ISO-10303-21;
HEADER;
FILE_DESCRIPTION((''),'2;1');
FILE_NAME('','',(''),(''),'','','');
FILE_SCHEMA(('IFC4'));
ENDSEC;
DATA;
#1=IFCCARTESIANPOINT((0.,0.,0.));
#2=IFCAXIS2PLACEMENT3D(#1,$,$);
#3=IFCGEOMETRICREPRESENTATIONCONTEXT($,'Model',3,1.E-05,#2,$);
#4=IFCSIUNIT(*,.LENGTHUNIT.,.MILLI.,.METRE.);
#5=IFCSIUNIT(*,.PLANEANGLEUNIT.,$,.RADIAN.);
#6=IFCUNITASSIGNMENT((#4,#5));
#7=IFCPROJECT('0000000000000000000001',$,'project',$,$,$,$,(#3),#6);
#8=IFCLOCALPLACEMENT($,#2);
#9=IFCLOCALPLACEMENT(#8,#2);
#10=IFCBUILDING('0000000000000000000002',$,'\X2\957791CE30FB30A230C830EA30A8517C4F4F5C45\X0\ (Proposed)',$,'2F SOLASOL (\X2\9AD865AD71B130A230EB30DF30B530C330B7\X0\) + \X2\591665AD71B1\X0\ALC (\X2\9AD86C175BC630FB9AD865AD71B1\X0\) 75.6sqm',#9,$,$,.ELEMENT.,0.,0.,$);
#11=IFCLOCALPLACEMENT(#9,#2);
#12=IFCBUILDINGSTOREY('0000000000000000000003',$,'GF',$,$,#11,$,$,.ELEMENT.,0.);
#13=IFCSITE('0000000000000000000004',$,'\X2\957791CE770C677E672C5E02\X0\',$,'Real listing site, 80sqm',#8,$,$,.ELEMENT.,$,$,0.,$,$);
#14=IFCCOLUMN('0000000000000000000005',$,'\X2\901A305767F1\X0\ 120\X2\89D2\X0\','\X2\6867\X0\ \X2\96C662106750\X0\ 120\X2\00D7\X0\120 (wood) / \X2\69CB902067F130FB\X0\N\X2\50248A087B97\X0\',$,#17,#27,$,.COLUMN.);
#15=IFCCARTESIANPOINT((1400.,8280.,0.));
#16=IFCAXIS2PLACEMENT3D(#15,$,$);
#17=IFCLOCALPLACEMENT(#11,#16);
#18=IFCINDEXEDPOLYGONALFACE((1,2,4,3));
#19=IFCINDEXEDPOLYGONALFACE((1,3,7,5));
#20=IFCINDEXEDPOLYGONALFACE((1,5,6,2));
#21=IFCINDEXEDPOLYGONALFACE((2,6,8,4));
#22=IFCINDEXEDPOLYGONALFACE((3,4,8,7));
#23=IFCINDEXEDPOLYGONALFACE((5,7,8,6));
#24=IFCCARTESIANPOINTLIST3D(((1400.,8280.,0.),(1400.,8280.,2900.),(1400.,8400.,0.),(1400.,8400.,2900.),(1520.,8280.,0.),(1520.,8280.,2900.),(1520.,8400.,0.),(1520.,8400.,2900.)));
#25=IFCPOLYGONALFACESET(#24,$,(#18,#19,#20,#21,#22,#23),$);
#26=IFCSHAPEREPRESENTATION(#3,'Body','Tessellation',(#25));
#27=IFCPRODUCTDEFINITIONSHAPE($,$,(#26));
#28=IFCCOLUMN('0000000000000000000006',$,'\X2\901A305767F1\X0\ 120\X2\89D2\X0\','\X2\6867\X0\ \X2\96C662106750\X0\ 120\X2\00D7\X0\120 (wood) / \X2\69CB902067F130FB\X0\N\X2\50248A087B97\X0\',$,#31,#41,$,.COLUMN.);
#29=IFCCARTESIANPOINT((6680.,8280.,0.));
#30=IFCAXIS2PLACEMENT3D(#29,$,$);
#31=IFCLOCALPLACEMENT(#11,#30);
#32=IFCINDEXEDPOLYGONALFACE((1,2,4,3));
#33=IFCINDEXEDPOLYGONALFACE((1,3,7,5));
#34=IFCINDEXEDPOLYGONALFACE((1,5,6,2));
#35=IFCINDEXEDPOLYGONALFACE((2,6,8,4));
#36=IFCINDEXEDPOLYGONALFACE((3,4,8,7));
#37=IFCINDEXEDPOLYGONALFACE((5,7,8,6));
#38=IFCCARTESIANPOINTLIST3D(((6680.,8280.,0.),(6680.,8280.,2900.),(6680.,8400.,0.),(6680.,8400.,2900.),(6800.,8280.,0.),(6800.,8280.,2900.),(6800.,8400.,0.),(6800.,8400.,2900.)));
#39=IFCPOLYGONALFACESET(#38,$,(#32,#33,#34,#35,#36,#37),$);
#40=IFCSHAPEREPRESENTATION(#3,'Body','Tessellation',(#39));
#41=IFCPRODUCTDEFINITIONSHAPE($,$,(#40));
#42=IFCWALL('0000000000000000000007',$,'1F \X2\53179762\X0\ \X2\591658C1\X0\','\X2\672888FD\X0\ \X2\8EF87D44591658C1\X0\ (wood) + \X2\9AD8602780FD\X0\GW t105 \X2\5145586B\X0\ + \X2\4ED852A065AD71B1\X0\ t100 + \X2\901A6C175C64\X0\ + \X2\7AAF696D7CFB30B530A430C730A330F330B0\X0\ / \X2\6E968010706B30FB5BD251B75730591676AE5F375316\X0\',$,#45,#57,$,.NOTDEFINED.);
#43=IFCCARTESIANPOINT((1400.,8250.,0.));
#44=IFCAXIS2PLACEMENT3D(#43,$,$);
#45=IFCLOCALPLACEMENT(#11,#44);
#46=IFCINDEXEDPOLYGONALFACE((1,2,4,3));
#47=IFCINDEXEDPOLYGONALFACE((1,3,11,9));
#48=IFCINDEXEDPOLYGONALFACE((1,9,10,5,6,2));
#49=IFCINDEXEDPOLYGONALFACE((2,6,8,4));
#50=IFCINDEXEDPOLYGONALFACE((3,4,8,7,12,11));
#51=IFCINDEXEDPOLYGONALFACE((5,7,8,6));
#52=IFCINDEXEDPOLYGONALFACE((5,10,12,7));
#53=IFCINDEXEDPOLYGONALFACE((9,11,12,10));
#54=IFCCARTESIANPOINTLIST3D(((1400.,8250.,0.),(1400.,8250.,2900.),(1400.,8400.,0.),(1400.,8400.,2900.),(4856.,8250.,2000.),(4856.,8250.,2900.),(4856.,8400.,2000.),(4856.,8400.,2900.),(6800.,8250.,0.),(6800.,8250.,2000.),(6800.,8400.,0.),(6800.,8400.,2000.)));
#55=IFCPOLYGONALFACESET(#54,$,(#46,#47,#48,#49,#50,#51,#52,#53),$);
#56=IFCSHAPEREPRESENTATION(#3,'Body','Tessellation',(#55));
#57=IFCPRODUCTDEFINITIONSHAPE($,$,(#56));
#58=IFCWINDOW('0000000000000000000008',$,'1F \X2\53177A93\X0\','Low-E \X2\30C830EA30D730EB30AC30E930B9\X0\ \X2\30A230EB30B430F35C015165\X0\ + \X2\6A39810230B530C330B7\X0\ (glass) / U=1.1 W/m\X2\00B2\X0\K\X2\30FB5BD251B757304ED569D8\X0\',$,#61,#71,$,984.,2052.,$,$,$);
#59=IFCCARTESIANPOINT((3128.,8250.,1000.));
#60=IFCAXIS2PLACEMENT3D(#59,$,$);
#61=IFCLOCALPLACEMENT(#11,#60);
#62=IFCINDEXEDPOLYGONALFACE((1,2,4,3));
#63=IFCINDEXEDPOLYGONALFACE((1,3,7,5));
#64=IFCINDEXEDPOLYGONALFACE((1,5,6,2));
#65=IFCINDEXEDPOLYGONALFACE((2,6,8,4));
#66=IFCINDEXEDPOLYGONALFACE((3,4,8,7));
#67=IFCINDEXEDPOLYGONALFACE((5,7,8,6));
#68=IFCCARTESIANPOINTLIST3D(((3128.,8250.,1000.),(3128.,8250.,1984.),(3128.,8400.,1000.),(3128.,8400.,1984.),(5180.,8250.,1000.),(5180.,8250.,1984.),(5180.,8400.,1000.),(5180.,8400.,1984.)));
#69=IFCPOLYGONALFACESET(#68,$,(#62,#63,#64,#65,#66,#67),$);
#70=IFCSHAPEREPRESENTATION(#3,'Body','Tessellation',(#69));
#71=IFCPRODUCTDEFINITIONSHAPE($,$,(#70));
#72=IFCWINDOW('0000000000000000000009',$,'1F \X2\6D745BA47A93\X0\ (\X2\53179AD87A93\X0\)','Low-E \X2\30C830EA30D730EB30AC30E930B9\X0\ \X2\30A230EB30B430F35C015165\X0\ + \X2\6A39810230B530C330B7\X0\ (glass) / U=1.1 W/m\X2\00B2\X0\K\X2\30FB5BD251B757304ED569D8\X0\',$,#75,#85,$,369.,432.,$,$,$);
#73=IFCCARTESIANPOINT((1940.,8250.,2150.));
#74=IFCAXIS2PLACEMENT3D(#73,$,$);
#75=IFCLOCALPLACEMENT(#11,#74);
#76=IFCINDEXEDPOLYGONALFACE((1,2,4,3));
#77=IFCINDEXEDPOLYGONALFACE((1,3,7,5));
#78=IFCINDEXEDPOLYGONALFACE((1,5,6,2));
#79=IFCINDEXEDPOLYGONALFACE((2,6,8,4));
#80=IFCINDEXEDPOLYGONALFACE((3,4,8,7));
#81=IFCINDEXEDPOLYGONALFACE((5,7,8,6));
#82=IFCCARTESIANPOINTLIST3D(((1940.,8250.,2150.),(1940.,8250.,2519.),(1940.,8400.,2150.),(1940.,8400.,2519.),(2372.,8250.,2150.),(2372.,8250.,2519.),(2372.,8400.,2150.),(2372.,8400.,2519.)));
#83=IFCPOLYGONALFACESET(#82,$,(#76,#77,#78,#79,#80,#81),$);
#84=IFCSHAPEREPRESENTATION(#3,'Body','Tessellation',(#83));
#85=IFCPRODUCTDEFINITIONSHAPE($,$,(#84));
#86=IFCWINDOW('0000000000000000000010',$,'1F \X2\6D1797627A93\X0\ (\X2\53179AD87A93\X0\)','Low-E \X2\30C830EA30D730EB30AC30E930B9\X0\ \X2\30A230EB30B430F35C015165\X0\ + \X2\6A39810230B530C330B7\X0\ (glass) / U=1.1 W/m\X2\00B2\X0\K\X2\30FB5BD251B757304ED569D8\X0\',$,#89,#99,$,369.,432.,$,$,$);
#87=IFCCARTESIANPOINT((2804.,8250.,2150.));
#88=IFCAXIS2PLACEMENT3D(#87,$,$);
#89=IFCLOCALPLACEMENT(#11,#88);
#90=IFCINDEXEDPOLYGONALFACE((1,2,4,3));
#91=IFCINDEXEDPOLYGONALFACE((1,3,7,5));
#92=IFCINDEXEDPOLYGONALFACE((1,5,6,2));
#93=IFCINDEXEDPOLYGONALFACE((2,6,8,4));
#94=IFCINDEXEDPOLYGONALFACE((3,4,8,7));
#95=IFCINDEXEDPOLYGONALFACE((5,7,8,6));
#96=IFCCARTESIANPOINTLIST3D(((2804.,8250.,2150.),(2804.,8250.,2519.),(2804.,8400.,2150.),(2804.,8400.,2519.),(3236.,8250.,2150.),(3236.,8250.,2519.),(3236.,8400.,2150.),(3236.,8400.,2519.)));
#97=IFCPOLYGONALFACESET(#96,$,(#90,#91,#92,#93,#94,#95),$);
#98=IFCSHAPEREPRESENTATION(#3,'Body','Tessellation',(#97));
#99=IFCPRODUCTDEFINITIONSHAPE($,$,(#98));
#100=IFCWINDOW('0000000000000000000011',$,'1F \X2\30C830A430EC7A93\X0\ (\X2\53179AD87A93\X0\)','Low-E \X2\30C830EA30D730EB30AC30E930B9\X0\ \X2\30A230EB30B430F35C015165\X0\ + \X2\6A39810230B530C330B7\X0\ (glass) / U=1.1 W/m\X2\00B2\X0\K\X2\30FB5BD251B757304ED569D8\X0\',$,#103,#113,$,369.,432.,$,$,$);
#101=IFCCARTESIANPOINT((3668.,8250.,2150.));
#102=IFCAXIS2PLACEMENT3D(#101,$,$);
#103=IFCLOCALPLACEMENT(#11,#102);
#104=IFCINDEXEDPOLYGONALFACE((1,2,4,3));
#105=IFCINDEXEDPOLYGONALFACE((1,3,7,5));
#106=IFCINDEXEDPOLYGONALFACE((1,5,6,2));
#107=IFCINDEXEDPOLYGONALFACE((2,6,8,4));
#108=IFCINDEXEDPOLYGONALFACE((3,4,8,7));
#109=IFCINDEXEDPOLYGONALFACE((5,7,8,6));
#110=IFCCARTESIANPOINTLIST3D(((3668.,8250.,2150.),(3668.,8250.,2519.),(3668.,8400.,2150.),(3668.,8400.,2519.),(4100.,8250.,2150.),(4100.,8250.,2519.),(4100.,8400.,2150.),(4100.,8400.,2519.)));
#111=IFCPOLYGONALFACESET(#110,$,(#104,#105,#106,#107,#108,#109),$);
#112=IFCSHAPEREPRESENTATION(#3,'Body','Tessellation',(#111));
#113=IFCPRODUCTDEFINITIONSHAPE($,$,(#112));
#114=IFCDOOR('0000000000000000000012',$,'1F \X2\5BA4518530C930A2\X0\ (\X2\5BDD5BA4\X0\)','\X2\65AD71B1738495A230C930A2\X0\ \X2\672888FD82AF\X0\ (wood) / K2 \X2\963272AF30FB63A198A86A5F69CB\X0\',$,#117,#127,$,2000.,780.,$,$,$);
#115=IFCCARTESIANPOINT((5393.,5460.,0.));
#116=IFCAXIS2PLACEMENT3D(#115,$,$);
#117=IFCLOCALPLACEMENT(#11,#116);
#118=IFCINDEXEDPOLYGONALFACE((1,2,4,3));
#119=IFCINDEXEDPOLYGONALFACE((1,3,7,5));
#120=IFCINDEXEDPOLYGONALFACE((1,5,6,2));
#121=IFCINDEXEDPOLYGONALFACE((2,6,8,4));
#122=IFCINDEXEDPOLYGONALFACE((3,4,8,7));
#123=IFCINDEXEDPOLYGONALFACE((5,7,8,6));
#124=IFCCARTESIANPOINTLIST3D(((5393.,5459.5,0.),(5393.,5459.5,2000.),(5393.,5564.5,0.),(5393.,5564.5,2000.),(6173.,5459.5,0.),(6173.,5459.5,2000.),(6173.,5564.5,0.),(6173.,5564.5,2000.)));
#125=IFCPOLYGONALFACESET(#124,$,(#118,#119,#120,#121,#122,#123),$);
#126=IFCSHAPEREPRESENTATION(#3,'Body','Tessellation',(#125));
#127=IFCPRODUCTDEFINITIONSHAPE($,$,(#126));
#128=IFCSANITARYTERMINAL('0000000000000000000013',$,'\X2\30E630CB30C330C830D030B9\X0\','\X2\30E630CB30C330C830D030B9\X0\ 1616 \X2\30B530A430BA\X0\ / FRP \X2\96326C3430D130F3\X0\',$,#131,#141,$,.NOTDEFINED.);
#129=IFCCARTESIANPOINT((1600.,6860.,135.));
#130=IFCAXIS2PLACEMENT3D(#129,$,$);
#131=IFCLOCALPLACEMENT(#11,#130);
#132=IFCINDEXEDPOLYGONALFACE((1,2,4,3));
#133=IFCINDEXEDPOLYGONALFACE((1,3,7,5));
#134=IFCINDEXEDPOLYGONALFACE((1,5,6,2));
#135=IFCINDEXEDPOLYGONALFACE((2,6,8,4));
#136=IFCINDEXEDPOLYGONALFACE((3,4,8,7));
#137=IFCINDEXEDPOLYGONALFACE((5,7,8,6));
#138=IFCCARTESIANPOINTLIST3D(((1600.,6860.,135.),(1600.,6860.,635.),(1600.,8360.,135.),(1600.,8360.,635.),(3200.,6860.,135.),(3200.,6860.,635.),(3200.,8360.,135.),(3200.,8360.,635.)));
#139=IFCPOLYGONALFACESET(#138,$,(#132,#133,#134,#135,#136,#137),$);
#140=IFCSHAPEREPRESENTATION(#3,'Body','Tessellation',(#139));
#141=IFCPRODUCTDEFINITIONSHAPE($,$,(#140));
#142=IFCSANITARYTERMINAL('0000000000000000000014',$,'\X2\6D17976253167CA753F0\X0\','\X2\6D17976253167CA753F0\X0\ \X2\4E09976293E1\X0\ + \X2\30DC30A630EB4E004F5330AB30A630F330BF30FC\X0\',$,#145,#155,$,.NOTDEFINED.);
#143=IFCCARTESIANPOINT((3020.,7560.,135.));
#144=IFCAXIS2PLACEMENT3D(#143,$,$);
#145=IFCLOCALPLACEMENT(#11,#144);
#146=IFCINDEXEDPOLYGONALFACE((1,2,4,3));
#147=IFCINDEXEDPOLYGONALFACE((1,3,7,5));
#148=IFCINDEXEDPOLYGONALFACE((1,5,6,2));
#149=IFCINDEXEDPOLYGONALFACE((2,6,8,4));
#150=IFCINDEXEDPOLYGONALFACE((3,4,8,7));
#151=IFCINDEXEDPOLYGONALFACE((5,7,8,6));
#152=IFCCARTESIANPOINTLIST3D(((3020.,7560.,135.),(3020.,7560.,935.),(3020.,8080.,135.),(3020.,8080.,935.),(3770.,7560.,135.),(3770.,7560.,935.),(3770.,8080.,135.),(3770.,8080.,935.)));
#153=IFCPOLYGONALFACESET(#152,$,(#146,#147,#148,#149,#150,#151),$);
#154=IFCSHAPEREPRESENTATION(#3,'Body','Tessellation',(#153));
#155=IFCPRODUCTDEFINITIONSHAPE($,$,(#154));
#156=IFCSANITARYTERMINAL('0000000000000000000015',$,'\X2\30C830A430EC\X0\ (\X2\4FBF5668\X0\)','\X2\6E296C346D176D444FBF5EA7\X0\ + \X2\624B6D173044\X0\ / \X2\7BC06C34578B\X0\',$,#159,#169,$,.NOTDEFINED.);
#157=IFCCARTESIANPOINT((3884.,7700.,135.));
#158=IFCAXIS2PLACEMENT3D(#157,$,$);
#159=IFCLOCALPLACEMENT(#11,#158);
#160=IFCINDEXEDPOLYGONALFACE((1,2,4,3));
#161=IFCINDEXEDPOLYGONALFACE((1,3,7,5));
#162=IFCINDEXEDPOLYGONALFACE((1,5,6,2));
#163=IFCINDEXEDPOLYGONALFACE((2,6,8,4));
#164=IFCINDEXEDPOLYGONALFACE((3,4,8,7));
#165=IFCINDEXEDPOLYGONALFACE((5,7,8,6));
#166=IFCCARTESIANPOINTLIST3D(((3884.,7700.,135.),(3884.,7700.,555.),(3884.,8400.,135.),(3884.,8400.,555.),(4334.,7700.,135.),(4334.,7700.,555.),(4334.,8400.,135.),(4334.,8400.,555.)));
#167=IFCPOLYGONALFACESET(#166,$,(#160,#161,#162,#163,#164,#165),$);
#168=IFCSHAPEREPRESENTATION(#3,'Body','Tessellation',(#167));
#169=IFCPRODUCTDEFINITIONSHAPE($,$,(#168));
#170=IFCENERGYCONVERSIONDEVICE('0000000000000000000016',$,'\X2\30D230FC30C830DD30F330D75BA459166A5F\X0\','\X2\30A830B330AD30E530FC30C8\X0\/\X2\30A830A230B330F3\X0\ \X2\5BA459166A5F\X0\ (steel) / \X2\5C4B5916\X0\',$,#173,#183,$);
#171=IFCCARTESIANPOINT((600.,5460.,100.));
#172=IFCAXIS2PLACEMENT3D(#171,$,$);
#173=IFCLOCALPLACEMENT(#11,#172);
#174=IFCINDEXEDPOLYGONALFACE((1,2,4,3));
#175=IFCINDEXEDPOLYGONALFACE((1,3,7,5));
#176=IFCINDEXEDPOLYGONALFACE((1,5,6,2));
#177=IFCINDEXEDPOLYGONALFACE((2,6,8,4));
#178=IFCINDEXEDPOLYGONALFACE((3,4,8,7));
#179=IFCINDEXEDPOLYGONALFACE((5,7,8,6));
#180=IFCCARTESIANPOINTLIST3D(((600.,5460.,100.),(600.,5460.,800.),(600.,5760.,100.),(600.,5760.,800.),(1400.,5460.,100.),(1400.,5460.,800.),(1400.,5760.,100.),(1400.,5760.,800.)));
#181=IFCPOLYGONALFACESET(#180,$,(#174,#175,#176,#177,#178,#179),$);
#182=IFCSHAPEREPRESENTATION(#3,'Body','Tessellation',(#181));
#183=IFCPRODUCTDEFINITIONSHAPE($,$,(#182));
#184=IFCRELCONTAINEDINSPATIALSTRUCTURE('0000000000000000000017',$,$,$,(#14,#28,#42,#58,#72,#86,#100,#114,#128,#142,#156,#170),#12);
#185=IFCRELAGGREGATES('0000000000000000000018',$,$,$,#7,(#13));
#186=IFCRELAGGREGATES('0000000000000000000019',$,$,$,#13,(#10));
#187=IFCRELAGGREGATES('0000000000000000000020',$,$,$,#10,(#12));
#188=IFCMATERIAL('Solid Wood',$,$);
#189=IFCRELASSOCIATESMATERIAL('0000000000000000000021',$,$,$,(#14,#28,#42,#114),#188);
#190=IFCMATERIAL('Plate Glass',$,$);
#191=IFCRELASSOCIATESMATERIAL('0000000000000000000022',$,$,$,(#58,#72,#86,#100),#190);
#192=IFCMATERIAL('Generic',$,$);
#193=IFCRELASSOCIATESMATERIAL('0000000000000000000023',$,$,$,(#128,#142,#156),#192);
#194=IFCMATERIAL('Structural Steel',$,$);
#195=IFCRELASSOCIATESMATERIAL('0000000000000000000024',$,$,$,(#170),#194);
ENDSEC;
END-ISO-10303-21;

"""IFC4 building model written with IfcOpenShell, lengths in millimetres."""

from ifc_helpers import new_model, si_unit, frame, frame_2d, origin, place, context, project, spatial, rectangle, extrude, material, element, fill, save


model = new_model("IFC4")

# Units and contexts
model_context = context("Model", 3, precision=1e-05, world=origin())
ifc_project = project(units=[si_unit("LENGTHUNIT", "METRE", prefix="MILLI"), si_unit("PLANEANGLEUNIT", "RADIAN")], contexts=[model_context])

# Site, building, storey
site_placement = place(None, origin())
site = spatial("IfcSite", under=ifc_project, at=site_placement, Name="長野県松本市", ObjectType="Real listing site, 80sqm", CompositionType="ELEMENT", RefElevation=0.0)
building_placement = place(site_placement, origin())
building = spatial("IfcBuilding", under=site, at=building_placement, Name="長野・アトリエ兼住居 (Proposed)", ObjectType="2F SOLASOL (高断熱アルミサッシ) + 外断熱ALC (高気密・高断熱) 75.6sqm", CompositionType="ELEMENT", ElevationOfRefHeight=0.0, ElevationOfTerrain=0.0)
storey_placement = place(building_placement, origin())
storey = spatial("IfcBuildingStorey", under=building, at=storey_placement, Name="GF", CompositionType="ELEMENT", Elevation=0.0)

# Columns
ifc_material_1 = material(Name="Solid Wood")
column_1_placement = place(storey_placement, frame((1400.0, 8280.0, 0.0)))
element("IfcColumn", 1, at=column_1_placement, inside=storey, material=ifc_material_1, Name="通し柱 120角", Description="桧 集成材 120×120 (wood) / 構造柱・N値計算", PredefinedType="COLUMN", context=model_context, shape_type="SweptSolid", body=[
    extrude(rectangle(XDim=120.0, YDim=120.0, at=frame_2d((60.0, 60.0))), frame((1400.0, 8280.0, 0.0)), (0.0, 0.0, 1.0), 2900.0),
])
column_2_placement = place(storey_placement, frame((6680.0, 8280.0, 0.0)))
element("IfcColumn", 2, at=column_2_placement, inside=storey, material=ifc_material_1, Name="通し柱 120角", Description="桧 集成材 120×120 (wood) / 構造柱・N値計算", PredefinedType="COLUMN", context=model_context, shape_type="SweptSolid", body=[
    extrude(rectangle(XDim=120.0, YDim=120.0, at=frame_2d((60.0, 60.0))), frame((6680.0, 8280.0, 0.0)), (0.0, 0.0, 1.0), 2900.0),
])

# Wall, openings, windows
wall_1_placement = place(storey_placement, frame((1400.0, 8250.0, 0.0)))
wall_1 = element("IfcWall", 3, at=wall_1_placement, inside=storey, material=ifc_material_1, Name="1F 北面 外壁", Description="木製 軸組外壁 (wood) + 高性能GW t105 充填 + 付加断熱 t100 + 通気層 + 窯業系サイディング / 準耐火・寒冷地外皮強化", PredefinedType="NOTDEFINED", context=model_context, shape_type="SweptSolid", body=[
    extrude(rectangle(XDim=5400.0, YDim=150.0, at=frame_2d((2700.0, 75.0))), frame((1400.0, 8250.0, 0.0)), (0.0, 0.0, 1.0), 2900.0),
])
opening_1_placement = place(storey_placement, frame((3128.0, 8250.0, 1000.0)))
opening_1 = element("IfcOpeningElement", 4, at=opening_1_placement, cuts=wall_1, PredefinedType="NOTDEFINED", context=model_context, shape_type="SweptSolid", body=[
    extrude(rectangle(XDim=2052.0, YDim=150.0, at=frame_2d((1026.0, 75.0))), frame((3128.0, 8250.0, 1000.0)), (0.0, 0.0, 1.0), 984.0),
])
opening_2_placement = place(storey_placement, frame((1940.0, 8250.0, 2150.0)))
opening_2 = element("IfcOpeningElement", 5, at=opening_2_placement, cuts=wall_1, PredefinedType="NOTDEFINED", context=model_context, shape_type="SweptSolid", body=[
    extrude(rectangle(XDim=432.0, YDim=150.0, at=frame_2d((216.0, 75.0))), frame((1940.0, 8250.0, 2150.0)), (0.0, 0.0, 1.0), 369.0),
])
opening_3_placement = place(storey_placement, frame((2804.0, 8250.0, 2150.0)))
opening_3 = element("IfcOpeningElement", 6, at=opening_3_placement, cuts=wall_1, PredefinedType="NOTDEFINED", context=model_context, shape_type="SweptSolid", body=[
    extrude(rectangle(XDim=432.0, YDim=150.0, at=frame_2d((216.0, 75.0))), frame((2804.0, 8250.0, 2150.0)), (0.0, 0.0, 1.0), 369.0),
])
opening_4_placement = place(storey_placement, frame((3668.0, 8250.0, 2150.0)))
opening_4 = element("IfcOpeningElement", 7, at=opening_4_placement, cuts=wall_1, PredefinedType="NOTDEFINED", context=model_context, shape_type="SweptSolid", body=[
    extrude(rectangle(XDim=432.0, YDim=150.0, at=frame_2d((216.0, 75.0))), frame((3668.0, 8250.0, 2150.0)), (0.0, 0.0, 1.0), 369.0),
])
ifc_material_2 = material(Name="Plate Glass")
window_1_placement = place(storey_placement, frame((3128.0, 8250.0, 1000.0)))
window_1 = element("IfcWindow", 8, at=window_1_placement, inside=storey, material=ifc_material_2, Name="1F 北窓", Description="Low-E トリプルガラス アルゴン封入 + 樹脂サッシ (glass) / U=1.1 W/m²K・寒冷地仕様", OverallHeight=984.0, OverallWidth=2052.0, context=model_context, shape_type="SweptSolid", body=[
    extrude(rectangle(XDim=2052.0, YDim=150.0, at=frame_2d((1026.0, 75.0))), frame((3128.0, 8250.0, 1000.0)), (0.0, 0.0, 1.0), 984.0),
])
fill(opening_1, window_1)
window_2_placement = place(storey_placement, frame((1940.0, 8250.0, 2150.0)))
window_2 = element("IfcWindow", 9, at=window_2_placement, inside=storey, material=ifc_material_2, Name="1F 浴室窓 (北高窓)", Description="Low-E トリプルガラス アルゴン封入 + 樹脂サッシ (glass) / U=1.1 W/m²K・寒冷地仕様", OverallHeight=369.0, OverallWidth=432.0, context=model_context, shape_type="SweptSolid", body=[
    extrude(rectangle(XDim=432.0, YDim=150.0, at=frame_2d((216.0, 75.0))), frame((1940.0, 8250.0, 2150.0)), (0.0, 0.0, 1.0), 369.0),
])
fill(opening_2, window_2)
window_3_placement = place(storey_placement, frame((2804.0, 8250.0, 2150.0)))
window_3 = element("IfcWindow", 10, at=window_3_placement, inside=storey, material=ifc_material_2, Name="1F 洗面窓 (北高窓)", Description="Low-E トリプルガラス アルゴン封入 + 樹脂サッシ (glass) / U=1.1 W/m²K・寒冷地仕様", OverallHeight=369.0, OverallWidth=432.0, context=model_context, shape_type="SweptSolid", body=[
    extrude(rectangle(XDim=432.0, YDim=150.0, at=frame_2d((216.0, 75.0))), frame((2804.0, 8250.0, 2150.0)), (0.0, 0.0, 1.0), 369.0),
])
fill(opening_3, window_3)
window_4_placement = place(storey_placement, frame((3668.0, 8250.0, 2150.0)))
window_4 = element("IfcWindow", 11, at=window_4_placement, inside=storey, material=ifc_material_2, Name="1F トイレ窓 (北高窓)", Description="Low-E トリプルガラス アルゴン封入 + 樹脂サッシ (glass) / U=1.1 W/m²K・寒冷地仕様", OverallHeight=369.0, OverallWidth=432.0, context=model_context, shape_type="SweptSolid", body=[
    extrude(rectangle(XDim=432.0, YDim=150.0, at=frame_2d((216.0, 75.0))), frame((3668.0, 8250.0, 2150.0)), (0.0, 0.0, 1.0), 369.0),
])
fill(opening_4, window_4)

# Door
door_1_placement = place(storey_placement, frame((5393.0, 5460.0, 0.0)))
element("IfcDoor", 12, at=door_1_placement, inside=storey, material=ifc_material_1, Name="1F 室内ドア (寝室)", Description="断熱玄関ドア 木製芯 (wood) / K2 防犯・採風機構", OverallHeight=2000.0, OverallWidth=780.0, context=model_context, shape_type="SweptSolid", body=[
    extrude(rectangle(XDim=780.0, YDim=105.0, at=frame_2d((390.0, 52.0))), frame((5393.0, 5460.0, 0.0)), (0.0, 0.0, 1.0), 2000.0),
])

# Sanitary terminals
ifc_material_3 = material(Name="Generic")
sanitary_terminal_1_placement = place(storey_placement, frame((1600.0, 6860.0, 135.0)))
element("IfcSanitaryTerminal", 13, at=sanitary_terminal_1_placement, inside=storey, material=ifc_material_3, Name="ユニットバス", Description="ユニットバス 1616 サイズ / FRP 防水パン", PredefinedType="NOTDEFINED", context=model_context, shape_type="SweptSolid", body=[
    extrude(rectangle(XDim=1600.0, YDim=1500.0, at=frame_2d((800.0, 750.0))), frame((1600.0, 6860.0, 135.0)), (0.0, 0.0, 1.0), 500.0),
])
sanitary_terminal_2_placement = place(storey_placement, frame((3020.0, 7560.0, 135.0)))
element("IfcSanitaryTerminal", 14, at=sanitary_terminal_2_placement, inside=storey, material=ifc_material_3, Name="洗面化粧台", Description="洗面化粧台 三面鏡 + ボウル一体カウンター", PredefinedType="NOTDEFINED", context=model_context, shape_type="SweptSolid", body=[
    extrude(rectangle(XDim=750.0, YDim=520.0, at=frame_2d((375.0, 260.0))), frame((3020.0, 7560.0, 135.0)), (0.0, 0.0, 1.0), 800.0),
])
sanitary_terminal_3_placement = place(storey_placement, frame((3884.0, 7700.0, 135.0)))
element("IfcSanitaryTerminal", 15, at=sanitary_terminal_3_placement, inside=storey, material=ifc_material_3, Name="トイレ (便器)", Description="温水洗浄便座 + 手洗い / 節水型", PredefinedType="NOTDEFINED", context=model_context, shape_type="SweptSolid", body=[
    extrude(rectangle(XDim=450.0, YDim=700.0, at=frame_2d((225.0, 350.0))), frame((3884.0, 7700.0, 135.0)), (0.0, 0.0, 1.0), 420.0),
])

# Shared definitions
ifc_material_4 = material(Name="Structural Steel")

# Energy conversion device
energy_conversion_device_placement = place(storey_placement, frame((600.0, 5460.0, 100.0)))
element("IfcEnergyConversionDevice", 16, at=energy_conversion_device_placement, inside=storey, material=ifc_material_4, Name="ヒートポンプ室外機", Description="エコキュート/エアコン 室外機 (steel) / 屋外", context=model_context, shape_type="SweptSolid", body=[
    extrude(rectangle(XDim=800.0, YDim=300.0, at=frame_2d((400.0, 150.0))), frame((600.0, 5460.0, 100.0)), (0.0, 0.0, 1.0), 700.0),
])

save(model, "model.ifc")
